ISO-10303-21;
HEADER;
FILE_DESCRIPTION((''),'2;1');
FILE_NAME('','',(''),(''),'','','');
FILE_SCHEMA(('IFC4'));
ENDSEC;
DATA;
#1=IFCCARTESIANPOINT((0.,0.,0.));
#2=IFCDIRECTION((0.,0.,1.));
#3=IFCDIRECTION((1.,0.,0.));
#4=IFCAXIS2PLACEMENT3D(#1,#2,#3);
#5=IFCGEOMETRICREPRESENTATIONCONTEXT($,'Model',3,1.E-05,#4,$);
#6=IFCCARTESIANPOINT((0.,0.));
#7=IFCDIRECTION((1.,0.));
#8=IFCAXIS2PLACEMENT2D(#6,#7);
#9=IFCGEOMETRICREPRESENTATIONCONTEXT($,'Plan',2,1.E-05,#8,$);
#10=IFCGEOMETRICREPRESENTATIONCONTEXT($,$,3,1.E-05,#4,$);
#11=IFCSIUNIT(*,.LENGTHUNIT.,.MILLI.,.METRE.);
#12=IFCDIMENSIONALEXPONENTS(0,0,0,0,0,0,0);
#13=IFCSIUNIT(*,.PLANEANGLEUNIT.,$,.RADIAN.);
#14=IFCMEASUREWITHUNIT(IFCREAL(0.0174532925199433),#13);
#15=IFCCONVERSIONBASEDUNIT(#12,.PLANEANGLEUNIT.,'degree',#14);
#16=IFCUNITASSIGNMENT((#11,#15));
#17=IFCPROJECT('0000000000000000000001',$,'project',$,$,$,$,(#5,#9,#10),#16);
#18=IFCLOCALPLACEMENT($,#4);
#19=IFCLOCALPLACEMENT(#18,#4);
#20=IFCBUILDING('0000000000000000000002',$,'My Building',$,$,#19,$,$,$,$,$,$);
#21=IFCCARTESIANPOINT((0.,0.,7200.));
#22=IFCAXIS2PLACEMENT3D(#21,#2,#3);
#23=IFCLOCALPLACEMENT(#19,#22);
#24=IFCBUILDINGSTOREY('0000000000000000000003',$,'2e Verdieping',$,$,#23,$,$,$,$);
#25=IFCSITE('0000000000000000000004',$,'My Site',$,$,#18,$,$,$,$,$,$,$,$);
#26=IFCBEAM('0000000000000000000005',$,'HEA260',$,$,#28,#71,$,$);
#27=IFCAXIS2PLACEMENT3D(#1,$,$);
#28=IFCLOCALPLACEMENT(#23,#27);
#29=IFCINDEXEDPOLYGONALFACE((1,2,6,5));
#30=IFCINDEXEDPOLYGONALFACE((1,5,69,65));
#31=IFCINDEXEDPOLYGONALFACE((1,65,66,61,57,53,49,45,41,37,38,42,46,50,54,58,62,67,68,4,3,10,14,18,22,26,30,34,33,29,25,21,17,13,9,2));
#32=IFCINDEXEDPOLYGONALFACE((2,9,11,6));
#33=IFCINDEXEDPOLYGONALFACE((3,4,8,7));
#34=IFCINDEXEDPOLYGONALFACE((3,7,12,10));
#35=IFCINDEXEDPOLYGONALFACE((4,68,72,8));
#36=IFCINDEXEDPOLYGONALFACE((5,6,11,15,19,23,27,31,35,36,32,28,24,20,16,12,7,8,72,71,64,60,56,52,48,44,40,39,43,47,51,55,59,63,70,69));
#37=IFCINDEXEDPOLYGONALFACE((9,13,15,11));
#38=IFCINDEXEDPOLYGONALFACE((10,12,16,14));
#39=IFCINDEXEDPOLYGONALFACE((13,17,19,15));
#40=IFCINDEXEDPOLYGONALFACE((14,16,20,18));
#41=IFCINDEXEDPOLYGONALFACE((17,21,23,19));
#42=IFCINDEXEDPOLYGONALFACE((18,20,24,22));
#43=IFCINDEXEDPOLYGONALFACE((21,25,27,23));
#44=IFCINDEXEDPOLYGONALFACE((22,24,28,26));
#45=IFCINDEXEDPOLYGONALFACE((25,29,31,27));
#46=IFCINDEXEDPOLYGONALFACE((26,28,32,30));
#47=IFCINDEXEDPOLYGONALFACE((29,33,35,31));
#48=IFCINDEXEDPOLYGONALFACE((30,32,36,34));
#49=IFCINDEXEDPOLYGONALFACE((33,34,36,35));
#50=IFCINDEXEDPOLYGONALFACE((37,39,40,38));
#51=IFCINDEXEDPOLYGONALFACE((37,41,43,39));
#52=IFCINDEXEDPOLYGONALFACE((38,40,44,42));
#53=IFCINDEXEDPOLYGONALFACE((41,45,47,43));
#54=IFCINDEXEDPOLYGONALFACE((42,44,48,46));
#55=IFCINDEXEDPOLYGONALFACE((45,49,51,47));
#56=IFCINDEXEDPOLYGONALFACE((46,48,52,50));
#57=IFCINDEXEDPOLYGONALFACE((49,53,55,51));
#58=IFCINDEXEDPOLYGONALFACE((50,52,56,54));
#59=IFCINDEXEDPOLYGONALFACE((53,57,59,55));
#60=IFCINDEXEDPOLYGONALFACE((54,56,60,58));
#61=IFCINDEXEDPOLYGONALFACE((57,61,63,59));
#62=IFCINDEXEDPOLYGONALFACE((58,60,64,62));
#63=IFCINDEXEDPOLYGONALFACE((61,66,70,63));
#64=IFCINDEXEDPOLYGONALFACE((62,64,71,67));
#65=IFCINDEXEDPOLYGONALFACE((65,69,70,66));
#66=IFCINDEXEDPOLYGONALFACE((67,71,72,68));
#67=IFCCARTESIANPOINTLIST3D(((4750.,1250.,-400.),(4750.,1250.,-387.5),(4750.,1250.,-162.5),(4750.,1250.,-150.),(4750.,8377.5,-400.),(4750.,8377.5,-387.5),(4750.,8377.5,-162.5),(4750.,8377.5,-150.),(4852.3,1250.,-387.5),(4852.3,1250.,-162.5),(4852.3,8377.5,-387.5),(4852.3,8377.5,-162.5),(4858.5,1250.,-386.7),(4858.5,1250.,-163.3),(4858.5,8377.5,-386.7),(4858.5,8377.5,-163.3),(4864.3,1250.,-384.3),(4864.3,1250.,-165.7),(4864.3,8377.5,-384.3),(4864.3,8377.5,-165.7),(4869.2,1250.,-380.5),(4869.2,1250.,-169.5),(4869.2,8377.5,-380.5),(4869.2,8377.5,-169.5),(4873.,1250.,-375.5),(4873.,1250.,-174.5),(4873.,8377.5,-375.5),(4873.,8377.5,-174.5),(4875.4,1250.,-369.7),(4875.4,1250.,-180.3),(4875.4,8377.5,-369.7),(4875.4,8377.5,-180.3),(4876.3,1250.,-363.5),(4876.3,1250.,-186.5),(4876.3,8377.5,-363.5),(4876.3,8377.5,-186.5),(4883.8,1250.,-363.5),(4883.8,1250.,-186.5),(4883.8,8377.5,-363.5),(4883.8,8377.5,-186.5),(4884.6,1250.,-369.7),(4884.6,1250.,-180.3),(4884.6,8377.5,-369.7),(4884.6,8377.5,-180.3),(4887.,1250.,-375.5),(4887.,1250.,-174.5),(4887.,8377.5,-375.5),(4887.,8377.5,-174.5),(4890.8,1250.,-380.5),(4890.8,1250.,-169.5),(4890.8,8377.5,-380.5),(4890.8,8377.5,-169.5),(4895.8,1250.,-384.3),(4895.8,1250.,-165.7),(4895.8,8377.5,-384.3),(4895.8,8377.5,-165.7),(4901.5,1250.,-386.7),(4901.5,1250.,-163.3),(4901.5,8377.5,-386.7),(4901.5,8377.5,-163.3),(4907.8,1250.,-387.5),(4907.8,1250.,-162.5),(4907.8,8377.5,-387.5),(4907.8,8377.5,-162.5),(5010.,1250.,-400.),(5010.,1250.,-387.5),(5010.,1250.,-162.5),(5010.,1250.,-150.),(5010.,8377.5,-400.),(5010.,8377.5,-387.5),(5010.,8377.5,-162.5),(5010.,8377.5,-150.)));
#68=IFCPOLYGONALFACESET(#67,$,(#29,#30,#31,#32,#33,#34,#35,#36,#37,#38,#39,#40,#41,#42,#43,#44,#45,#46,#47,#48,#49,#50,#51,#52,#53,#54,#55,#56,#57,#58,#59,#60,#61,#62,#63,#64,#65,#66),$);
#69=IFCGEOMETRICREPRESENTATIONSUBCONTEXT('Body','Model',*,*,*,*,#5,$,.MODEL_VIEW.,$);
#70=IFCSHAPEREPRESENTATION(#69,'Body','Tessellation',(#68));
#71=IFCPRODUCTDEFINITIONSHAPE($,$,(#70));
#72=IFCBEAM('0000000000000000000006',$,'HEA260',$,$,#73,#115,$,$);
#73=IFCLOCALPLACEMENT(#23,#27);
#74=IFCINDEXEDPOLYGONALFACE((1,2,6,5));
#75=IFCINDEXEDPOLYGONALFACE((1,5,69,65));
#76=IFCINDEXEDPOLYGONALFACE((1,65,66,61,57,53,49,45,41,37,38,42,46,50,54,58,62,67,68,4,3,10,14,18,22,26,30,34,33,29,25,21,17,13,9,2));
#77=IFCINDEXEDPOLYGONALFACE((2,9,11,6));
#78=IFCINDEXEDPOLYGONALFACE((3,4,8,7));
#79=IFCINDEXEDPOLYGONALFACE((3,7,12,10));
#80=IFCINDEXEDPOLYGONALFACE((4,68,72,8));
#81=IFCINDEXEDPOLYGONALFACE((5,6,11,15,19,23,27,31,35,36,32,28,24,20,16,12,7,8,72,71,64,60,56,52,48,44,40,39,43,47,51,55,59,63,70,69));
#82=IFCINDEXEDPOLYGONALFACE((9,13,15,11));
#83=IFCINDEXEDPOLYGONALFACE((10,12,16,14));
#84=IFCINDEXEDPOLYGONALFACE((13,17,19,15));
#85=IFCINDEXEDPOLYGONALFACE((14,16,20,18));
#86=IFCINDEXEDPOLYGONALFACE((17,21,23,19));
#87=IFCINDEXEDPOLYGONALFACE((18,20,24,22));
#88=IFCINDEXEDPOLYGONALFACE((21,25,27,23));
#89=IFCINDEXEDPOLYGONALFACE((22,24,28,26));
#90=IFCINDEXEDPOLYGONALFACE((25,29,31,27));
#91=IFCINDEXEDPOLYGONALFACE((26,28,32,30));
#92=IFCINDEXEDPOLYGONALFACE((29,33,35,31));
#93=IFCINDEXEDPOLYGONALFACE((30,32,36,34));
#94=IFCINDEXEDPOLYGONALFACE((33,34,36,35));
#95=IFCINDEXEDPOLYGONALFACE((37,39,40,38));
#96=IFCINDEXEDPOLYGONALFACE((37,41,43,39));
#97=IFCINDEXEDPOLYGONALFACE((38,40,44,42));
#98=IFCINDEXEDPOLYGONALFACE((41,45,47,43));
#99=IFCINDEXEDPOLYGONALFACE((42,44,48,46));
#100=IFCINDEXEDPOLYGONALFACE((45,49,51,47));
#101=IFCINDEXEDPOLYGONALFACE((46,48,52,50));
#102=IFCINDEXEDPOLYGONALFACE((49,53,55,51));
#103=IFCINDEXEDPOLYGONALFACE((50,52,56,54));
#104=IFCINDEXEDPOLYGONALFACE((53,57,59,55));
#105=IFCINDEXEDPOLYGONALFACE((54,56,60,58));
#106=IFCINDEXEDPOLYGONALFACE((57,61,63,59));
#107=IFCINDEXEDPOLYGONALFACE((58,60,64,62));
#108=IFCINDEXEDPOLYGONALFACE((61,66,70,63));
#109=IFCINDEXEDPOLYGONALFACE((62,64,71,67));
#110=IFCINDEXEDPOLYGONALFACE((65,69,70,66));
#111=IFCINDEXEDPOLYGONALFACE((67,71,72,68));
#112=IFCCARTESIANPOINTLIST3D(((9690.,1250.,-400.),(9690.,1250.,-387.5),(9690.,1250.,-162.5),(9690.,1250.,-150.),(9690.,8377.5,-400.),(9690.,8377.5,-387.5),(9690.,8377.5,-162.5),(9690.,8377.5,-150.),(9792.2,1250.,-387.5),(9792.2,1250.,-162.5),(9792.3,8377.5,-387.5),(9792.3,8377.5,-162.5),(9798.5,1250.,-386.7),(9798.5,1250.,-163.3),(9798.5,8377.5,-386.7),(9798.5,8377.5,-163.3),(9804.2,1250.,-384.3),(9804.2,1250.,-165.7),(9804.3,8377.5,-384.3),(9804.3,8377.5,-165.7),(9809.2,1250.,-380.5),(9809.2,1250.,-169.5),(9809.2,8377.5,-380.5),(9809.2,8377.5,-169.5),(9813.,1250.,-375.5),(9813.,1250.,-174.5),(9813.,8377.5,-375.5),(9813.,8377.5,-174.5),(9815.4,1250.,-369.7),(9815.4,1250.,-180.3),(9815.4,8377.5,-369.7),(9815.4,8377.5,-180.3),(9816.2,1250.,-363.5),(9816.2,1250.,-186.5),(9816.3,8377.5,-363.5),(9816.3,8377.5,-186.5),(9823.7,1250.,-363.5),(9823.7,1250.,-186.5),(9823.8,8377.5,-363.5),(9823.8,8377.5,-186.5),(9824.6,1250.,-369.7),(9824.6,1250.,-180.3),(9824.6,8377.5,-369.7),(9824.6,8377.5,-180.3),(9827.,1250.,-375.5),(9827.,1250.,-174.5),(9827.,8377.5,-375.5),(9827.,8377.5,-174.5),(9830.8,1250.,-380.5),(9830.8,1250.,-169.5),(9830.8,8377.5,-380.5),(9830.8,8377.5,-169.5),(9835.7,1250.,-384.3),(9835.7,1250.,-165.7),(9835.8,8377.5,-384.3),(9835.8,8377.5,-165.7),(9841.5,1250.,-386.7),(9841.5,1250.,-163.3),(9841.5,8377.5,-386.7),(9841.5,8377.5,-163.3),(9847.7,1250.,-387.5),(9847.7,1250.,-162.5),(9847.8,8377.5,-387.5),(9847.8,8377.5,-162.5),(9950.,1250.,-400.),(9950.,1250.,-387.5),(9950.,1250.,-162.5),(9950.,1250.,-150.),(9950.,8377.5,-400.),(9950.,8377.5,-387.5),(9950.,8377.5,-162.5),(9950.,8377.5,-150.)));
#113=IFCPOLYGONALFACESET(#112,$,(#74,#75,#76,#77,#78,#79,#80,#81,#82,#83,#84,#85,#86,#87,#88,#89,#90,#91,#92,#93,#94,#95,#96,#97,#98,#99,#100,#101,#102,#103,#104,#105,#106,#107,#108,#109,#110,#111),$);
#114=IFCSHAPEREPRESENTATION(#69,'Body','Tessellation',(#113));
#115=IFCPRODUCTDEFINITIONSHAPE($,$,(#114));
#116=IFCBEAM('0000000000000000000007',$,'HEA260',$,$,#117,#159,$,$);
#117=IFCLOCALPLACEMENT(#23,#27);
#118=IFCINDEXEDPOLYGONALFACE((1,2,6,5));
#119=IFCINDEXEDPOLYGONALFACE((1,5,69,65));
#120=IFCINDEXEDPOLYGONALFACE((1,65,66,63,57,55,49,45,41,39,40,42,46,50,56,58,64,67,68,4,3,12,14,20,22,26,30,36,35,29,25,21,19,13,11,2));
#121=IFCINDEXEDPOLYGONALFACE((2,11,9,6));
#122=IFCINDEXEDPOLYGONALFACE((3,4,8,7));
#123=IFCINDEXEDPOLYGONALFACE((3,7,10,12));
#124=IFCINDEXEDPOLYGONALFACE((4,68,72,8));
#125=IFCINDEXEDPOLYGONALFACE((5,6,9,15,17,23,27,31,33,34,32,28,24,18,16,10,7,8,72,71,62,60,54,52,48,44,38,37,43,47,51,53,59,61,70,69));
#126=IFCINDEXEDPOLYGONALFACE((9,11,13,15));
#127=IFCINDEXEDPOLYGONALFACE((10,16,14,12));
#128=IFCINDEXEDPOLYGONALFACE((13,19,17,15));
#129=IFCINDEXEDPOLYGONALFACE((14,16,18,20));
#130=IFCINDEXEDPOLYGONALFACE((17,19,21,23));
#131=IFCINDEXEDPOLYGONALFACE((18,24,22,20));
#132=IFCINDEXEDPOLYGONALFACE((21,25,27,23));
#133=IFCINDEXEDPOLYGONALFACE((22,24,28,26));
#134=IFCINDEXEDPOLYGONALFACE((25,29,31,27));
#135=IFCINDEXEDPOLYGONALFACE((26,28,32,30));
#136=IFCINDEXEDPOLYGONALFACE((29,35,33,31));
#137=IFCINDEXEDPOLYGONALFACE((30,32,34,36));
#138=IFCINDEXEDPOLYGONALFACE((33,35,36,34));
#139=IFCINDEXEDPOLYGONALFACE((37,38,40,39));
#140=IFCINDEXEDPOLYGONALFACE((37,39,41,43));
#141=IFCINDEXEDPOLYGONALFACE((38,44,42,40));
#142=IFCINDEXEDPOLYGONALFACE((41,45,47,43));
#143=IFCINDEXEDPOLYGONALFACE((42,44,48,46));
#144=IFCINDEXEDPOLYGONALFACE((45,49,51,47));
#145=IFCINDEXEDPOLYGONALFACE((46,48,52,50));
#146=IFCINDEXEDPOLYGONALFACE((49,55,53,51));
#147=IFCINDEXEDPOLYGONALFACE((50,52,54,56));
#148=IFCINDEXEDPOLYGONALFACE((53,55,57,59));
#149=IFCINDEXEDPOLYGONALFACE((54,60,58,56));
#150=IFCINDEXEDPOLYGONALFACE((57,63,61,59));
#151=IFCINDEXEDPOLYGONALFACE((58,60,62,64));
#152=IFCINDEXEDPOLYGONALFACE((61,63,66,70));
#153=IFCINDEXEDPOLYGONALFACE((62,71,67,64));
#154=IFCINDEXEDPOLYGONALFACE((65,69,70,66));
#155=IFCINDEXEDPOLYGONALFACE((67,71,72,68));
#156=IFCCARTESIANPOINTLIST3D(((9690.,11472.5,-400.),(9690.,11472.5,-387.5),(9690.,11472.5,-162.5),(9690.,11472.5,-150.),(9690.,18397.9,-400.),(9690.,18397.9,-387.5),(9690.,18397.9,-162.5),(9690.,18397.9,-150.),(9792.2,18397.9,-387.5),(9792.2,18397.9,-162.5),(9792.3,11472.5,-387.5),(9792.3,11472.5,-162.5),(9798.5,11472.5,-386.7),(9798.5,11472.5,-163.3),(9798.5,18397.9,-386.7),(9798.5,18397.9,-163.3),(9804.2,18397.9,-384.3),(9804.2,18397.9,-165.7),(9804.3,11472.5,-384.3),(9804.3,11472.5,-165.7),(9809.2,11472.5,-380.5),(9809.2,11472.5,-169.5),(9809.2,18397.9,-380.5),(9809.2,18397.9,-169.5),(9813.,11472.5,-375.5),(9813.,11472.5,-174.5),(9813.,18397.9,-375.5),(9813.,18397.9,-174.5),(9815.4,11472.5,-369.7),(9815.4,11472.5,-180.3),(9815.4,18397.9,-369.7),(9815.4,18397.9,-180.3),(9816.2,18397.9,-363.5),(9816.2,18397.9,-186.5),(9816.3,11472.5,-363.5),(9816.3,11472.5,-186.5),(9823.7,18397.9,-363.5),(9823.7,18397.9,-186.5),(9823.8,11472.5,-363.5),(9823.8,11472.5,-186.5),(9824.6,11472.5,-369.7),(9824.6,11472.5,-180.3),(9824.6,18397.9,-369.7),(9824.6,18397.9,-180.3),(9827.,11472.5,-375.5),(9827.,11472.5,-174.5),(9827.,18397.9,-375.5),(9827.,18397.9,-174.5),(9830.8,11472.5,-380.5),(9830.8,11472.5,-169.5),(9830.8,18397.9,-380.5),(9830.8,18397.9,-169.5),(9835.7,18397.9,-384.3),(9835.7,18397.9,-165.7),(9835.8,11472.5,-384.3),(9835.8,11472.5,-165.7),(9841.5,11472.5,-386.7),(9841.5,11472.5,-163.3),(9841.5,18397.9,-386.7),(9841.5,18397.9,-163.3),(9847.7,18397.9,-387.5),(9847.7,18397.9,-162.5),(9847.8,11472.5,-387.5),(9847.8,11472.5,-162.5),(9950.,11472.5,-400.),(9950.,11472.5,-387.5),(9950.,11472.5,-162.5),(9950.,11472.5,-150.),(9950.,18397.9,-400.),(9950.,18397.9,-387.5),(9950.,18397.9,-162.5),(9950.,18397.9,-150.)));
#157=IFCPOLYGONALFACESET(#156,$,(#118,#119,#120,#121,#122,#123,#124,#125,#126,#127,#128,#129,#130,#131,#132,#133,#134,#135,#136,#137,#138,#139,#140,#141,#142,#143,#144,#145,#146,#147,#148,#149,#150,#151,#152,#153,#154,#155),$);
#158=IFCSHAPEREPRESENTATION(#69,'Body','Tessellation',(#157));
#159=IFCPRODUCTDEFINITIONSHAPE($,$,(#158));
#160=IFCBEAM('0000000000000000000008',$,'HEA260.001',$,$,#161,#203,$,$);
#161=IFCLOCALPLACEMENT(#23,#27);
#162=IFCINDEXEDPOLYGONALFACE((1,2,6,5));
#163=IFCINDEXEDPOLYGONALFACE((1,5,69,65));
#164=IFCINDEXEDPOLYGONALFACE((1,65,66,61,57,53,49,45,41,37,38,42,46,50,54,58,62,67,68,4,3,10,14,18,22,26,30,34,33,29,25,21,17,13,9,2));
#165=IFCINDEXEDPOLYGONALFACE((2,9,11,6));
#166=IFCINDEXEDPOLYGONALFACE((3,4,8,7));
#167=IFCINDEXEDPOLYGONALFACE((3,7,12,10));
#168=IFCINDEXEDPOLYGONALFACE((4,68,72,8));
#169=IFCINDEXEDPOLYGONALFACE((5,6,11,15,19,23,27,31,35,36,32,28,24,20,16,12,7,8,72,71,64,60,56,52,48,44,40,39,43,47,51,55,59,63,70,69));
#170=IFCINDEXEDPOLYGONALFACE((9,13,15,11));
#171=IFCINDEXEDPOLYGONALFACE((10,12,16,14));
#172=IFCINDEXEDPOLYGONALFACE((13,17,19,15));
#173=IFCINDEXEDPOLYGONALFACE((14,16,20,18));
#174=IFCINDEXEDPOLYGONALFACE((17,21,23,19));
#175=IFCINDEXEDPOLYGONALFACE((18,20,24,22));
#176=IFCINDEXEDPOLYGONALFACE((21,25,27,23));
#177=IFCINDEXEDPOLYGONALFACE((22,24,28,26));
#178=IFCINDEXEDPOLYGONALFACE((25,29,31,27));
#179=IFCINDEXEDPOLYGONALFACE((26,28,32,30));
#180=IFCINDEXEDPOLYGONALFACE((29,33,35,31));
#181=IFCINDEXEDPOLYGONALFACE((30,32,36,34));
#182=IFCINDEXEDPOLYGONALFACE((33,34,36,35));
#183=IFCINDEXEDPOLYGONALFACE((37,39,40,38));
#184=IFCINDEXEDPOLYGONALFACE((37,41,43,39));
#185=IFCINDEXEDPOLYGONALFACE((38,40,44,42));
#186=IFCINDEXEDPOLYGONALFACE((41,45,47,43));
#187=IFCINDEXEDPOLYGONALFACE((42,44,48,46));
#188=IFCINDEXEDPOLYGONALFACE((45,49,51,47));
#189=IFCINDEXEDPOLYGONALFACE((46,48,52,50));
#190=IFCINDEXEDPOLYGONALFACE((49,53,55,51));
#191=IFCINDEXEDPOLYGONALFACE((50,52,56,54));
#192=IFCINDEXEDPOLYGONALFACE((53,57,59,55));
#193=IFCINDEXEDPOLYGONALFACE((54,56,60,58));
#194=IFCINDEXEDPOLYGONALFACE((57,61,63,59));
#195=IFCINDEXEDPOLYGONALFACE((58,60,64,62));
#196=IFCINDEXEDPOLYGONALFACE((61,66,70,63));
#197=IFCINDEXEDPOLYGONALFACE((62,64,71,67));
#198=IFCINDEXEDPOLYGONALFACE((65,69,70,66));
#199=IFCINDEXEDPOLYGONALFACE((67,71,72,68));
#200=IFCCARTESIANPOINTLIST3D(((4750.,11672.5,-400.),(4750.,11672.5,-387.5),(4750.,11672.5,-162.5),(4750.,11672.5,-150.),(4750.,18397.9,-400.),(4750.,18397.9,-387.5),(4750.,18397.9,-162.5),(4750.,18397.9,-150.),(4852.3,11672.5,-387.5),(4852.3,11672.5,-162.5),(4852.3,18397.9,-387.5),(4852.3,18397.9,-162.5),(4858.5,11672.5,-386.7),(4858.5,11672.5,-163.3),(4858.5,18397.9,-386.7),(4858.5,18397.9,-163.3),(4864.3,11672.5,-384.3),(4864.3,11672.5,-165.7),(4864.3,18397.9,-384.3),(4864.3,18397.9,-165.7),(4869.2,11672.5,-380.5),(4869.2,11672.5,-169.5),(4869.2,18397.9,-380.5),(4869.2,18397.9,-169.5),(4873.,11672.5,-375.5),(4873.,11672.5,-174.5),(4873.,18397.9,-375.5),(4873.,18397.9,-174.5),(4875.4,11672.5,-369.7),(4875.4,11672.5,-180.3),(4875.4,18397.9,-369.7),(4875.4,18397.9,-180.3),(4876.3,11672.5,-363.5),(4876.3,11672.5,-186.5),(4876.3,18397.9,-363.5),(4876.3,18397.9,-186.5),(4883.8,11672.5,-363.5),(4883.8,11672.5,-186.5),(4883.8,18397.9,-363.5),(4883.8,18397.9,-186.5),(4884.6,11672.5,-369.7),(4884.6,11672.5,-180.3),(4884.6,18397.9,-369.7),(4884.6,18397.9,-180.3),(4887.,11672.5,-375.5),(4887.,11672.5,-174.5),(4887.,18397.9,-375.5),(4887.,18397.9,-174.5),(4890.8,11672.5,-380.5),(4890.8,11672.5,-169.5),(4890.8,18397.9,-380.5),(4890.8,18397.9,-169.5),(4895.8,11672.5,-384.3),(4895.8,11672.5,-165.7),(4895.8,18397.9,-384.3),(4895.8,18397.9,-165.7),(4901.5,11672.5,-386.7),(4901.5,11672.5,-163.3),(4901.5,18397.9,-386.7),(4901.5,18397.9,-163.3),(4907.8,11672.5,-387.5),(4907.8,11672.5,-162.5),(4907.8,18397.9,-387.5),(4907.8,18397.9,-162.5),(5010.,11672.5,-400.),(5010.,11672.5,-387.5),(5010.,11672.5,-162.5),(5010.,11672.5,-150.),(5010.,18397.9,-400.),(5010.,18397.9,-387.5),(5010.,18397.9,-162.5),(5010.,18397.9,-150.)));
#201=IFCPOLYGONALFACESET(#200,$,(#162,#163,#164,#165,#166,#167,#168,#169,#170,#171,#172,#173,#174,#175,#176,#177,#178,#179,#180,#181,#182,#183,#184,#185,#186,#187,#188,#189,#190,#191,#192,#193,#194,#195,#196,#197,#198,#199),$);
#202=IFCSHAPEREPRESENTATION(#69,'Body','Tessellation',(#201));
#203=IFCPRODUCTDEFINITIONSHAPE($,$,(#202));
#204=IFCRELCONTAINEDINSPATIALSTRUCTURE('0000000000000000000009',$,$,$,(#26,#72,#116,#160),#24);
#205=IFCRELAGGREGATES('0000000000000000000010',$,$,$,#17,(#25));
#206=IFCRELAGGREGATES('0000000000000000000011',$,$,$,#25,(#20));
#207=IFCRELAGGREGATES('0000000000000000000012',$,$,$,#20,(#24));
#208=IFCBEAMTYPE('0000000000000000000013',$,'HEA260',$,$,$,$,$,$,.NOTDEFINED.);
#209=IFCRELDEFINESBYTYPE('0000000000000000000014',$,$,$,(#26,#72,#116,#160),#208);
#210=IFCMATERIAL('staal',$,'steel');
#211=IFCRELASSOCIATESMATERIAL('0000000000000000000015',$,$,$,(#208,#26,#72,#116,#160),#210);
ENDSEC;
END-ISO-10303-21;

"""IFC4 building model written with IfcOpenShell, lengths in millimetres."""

from ifc_helpers import new_model, entity, si_unit, converted_unit, frame, origin_with_axes, origin_2d_with_axis, place, context, subcontext, project, spatial, i_section, extrude, material, material_profile, profile_set, profile_usage, type_object, element, save


model = new_model("IFC4")

# Units and contexts
model_context = context("Model", 3, precision=1e-05, world=origin_with_axes())
plan_context = context("Plan", 2, precision=1e-05, world=origin_2d_with_axis())
context_of_model = context(None, 3, precision=1e-05, world=origin_with_axes())
body_context = subcontext(model_context, "Body", "Model", "MODEL_VIEW")
ifc_project = project(units=[si_unit("LENGTHUNIT", "METRE", prefix="MILLI"), converted_unit("PLANEANGLEUNIT", "degree", entity("IfcReal", 0.0174532925199433), si_unit("PLANEANGLEUNIT", "RADIAN"), dimensions=[0, 0, 0, 0, 0, 0, 0])], contexts=[model_context, plan_context, context_of_model])

# Site, building, storey
site_placement = place(None, origin_with_axes())
site = spatial("IfcSite", under=ifc_project, at=site_placement, Name="My Site")
building_placement = place(site_placement, origin_with_axes())
building = spatial("IfcBuilding", under=site, at=building_placement, Name="My Building")
storey_placement = place(building_placement, frame((0.0, 0.0, 7200.0), z_axis=(0.0, 0.0, 1.0), x_axis=(1.0, 0.0, 0.0)))
storey = spatial("IfcBuildingStorey", under=building, at=storey_placement, Name="2e Verdieping")

# Beams
ifc_material_1 = material(Name="staal", Category="steel")
ifc_material_profile_1 = material_profile(ifc_material_1, i_section(OverallWidth=260.0, OverallDepth=250.0, WebThickness=7.5, FlangeThickness=12.5, FilletRadius=24.0))
ifc_profile_set_1 = profile_set([ifc_material_profile_1], Name="HEA260")
ifc_profile_usage_1 = profile_usage(ifc_profile_set_1)
beam_type_1 = type_object("IfcBeamType", Name="HEA260", PredefinedType="NOTDEFINED", material=ifc_profile_set_1)
beam_1_placement = place(storey_placement, frame((4880.0, 1250.0, -275.0), z_axis=(0.0, 1.0, 0.0), x_axis=(-1.0, 0.0, 0.0)))
element("IfcBeam", 1, at=beam_1_placement, inside=storey, type_object=beam_type_1, material=ifc_profile_usage_1, Name="HEA260", context=body_context, shape_type="SweptSolid", body=[
    extrude(i_section(OverallWidth=260.0, OverallDepth=250.0, WebThickness=7.5, FlangeThickness=12.5, FilletRadius=24.0), origin_with_axes(), (0.0, 0.0, 1.0), 7127.5),
])
ifc_profile_usage_2 = profile_usage(ifc_profile_set_1)
beam_2_placement = place(storey_placement, frame((9820.0, 1250.0, -275.0), z_axis=(0.0, 1.0, 0.0), x_axis=(-1.0, 0.0, 0.0)))
element("IfcBeam", 2, at=beam_2_placement, inside=storey, type_object=beam_type_1, material=ifc_profile_usage_2, Name="HEA260", context=body_context, shape_type="SweptSolid", body=[
    extrude(i_section(OverallWidth=260.0, OverallDepth=250.0, WebThickness=7.5, FlangeThickness=12.5, FilletRadius=24.0), origin_with_axes(), (0.0, 0.0, 1.0), 7127.5),
])
ifc_profile_usage_3 = profile_usage(ifc_profile_set_1)
beam_3_placement = place(storey_placement, frame((9820.0, 18397.9, -275.0), z_axis=(0.0, -1.0, 0.0), x_axis=(1.0, 0.0, 0.0)))
element("IfcBeam", 3, at=beam_3_placement, inside=storey, type_object=beam_type_1, material=ifc_profile_usage_3, Name="HEA260", context=body_context, shape_type="SweptSolid", body=[
    extrude(i_section(OverallWidth=260.0, OverallDepth=250.0, WebThickness=7.5, FlangeThickness=12.5, FilletRadius=24.0), origin_with_axes(), (0.0, 0.0, 1.0), 6925.4),
])
ifc_profile_usage_4 = profile_usage(ifc_profile_set_1)
beam_4_placement = place(storey_placement, frame((4880.0, 18397.9, -275.0), z_axis=(0.0, -1.0, 0.0), x_axis=(1.0, 0.0, 0.0)))
element("IfcBeam", 4, at=beam_4_placement, inside=storey, type_object=beam_type_1, material=ifc_profile_usage_4, Name="HEA260.001", context=body_context, shape_type="SweptSolid", body=[
    extrude(i_section(OverallWidth=260.0, OverallDepth=250.0, WebThickness=7.5, FlangeThickness=12.5, FilletRadius=24.0), origin_with_axes(), (0.0, 0.0, 1.0), 6725.4),
])

save(model, "model.ifc")
